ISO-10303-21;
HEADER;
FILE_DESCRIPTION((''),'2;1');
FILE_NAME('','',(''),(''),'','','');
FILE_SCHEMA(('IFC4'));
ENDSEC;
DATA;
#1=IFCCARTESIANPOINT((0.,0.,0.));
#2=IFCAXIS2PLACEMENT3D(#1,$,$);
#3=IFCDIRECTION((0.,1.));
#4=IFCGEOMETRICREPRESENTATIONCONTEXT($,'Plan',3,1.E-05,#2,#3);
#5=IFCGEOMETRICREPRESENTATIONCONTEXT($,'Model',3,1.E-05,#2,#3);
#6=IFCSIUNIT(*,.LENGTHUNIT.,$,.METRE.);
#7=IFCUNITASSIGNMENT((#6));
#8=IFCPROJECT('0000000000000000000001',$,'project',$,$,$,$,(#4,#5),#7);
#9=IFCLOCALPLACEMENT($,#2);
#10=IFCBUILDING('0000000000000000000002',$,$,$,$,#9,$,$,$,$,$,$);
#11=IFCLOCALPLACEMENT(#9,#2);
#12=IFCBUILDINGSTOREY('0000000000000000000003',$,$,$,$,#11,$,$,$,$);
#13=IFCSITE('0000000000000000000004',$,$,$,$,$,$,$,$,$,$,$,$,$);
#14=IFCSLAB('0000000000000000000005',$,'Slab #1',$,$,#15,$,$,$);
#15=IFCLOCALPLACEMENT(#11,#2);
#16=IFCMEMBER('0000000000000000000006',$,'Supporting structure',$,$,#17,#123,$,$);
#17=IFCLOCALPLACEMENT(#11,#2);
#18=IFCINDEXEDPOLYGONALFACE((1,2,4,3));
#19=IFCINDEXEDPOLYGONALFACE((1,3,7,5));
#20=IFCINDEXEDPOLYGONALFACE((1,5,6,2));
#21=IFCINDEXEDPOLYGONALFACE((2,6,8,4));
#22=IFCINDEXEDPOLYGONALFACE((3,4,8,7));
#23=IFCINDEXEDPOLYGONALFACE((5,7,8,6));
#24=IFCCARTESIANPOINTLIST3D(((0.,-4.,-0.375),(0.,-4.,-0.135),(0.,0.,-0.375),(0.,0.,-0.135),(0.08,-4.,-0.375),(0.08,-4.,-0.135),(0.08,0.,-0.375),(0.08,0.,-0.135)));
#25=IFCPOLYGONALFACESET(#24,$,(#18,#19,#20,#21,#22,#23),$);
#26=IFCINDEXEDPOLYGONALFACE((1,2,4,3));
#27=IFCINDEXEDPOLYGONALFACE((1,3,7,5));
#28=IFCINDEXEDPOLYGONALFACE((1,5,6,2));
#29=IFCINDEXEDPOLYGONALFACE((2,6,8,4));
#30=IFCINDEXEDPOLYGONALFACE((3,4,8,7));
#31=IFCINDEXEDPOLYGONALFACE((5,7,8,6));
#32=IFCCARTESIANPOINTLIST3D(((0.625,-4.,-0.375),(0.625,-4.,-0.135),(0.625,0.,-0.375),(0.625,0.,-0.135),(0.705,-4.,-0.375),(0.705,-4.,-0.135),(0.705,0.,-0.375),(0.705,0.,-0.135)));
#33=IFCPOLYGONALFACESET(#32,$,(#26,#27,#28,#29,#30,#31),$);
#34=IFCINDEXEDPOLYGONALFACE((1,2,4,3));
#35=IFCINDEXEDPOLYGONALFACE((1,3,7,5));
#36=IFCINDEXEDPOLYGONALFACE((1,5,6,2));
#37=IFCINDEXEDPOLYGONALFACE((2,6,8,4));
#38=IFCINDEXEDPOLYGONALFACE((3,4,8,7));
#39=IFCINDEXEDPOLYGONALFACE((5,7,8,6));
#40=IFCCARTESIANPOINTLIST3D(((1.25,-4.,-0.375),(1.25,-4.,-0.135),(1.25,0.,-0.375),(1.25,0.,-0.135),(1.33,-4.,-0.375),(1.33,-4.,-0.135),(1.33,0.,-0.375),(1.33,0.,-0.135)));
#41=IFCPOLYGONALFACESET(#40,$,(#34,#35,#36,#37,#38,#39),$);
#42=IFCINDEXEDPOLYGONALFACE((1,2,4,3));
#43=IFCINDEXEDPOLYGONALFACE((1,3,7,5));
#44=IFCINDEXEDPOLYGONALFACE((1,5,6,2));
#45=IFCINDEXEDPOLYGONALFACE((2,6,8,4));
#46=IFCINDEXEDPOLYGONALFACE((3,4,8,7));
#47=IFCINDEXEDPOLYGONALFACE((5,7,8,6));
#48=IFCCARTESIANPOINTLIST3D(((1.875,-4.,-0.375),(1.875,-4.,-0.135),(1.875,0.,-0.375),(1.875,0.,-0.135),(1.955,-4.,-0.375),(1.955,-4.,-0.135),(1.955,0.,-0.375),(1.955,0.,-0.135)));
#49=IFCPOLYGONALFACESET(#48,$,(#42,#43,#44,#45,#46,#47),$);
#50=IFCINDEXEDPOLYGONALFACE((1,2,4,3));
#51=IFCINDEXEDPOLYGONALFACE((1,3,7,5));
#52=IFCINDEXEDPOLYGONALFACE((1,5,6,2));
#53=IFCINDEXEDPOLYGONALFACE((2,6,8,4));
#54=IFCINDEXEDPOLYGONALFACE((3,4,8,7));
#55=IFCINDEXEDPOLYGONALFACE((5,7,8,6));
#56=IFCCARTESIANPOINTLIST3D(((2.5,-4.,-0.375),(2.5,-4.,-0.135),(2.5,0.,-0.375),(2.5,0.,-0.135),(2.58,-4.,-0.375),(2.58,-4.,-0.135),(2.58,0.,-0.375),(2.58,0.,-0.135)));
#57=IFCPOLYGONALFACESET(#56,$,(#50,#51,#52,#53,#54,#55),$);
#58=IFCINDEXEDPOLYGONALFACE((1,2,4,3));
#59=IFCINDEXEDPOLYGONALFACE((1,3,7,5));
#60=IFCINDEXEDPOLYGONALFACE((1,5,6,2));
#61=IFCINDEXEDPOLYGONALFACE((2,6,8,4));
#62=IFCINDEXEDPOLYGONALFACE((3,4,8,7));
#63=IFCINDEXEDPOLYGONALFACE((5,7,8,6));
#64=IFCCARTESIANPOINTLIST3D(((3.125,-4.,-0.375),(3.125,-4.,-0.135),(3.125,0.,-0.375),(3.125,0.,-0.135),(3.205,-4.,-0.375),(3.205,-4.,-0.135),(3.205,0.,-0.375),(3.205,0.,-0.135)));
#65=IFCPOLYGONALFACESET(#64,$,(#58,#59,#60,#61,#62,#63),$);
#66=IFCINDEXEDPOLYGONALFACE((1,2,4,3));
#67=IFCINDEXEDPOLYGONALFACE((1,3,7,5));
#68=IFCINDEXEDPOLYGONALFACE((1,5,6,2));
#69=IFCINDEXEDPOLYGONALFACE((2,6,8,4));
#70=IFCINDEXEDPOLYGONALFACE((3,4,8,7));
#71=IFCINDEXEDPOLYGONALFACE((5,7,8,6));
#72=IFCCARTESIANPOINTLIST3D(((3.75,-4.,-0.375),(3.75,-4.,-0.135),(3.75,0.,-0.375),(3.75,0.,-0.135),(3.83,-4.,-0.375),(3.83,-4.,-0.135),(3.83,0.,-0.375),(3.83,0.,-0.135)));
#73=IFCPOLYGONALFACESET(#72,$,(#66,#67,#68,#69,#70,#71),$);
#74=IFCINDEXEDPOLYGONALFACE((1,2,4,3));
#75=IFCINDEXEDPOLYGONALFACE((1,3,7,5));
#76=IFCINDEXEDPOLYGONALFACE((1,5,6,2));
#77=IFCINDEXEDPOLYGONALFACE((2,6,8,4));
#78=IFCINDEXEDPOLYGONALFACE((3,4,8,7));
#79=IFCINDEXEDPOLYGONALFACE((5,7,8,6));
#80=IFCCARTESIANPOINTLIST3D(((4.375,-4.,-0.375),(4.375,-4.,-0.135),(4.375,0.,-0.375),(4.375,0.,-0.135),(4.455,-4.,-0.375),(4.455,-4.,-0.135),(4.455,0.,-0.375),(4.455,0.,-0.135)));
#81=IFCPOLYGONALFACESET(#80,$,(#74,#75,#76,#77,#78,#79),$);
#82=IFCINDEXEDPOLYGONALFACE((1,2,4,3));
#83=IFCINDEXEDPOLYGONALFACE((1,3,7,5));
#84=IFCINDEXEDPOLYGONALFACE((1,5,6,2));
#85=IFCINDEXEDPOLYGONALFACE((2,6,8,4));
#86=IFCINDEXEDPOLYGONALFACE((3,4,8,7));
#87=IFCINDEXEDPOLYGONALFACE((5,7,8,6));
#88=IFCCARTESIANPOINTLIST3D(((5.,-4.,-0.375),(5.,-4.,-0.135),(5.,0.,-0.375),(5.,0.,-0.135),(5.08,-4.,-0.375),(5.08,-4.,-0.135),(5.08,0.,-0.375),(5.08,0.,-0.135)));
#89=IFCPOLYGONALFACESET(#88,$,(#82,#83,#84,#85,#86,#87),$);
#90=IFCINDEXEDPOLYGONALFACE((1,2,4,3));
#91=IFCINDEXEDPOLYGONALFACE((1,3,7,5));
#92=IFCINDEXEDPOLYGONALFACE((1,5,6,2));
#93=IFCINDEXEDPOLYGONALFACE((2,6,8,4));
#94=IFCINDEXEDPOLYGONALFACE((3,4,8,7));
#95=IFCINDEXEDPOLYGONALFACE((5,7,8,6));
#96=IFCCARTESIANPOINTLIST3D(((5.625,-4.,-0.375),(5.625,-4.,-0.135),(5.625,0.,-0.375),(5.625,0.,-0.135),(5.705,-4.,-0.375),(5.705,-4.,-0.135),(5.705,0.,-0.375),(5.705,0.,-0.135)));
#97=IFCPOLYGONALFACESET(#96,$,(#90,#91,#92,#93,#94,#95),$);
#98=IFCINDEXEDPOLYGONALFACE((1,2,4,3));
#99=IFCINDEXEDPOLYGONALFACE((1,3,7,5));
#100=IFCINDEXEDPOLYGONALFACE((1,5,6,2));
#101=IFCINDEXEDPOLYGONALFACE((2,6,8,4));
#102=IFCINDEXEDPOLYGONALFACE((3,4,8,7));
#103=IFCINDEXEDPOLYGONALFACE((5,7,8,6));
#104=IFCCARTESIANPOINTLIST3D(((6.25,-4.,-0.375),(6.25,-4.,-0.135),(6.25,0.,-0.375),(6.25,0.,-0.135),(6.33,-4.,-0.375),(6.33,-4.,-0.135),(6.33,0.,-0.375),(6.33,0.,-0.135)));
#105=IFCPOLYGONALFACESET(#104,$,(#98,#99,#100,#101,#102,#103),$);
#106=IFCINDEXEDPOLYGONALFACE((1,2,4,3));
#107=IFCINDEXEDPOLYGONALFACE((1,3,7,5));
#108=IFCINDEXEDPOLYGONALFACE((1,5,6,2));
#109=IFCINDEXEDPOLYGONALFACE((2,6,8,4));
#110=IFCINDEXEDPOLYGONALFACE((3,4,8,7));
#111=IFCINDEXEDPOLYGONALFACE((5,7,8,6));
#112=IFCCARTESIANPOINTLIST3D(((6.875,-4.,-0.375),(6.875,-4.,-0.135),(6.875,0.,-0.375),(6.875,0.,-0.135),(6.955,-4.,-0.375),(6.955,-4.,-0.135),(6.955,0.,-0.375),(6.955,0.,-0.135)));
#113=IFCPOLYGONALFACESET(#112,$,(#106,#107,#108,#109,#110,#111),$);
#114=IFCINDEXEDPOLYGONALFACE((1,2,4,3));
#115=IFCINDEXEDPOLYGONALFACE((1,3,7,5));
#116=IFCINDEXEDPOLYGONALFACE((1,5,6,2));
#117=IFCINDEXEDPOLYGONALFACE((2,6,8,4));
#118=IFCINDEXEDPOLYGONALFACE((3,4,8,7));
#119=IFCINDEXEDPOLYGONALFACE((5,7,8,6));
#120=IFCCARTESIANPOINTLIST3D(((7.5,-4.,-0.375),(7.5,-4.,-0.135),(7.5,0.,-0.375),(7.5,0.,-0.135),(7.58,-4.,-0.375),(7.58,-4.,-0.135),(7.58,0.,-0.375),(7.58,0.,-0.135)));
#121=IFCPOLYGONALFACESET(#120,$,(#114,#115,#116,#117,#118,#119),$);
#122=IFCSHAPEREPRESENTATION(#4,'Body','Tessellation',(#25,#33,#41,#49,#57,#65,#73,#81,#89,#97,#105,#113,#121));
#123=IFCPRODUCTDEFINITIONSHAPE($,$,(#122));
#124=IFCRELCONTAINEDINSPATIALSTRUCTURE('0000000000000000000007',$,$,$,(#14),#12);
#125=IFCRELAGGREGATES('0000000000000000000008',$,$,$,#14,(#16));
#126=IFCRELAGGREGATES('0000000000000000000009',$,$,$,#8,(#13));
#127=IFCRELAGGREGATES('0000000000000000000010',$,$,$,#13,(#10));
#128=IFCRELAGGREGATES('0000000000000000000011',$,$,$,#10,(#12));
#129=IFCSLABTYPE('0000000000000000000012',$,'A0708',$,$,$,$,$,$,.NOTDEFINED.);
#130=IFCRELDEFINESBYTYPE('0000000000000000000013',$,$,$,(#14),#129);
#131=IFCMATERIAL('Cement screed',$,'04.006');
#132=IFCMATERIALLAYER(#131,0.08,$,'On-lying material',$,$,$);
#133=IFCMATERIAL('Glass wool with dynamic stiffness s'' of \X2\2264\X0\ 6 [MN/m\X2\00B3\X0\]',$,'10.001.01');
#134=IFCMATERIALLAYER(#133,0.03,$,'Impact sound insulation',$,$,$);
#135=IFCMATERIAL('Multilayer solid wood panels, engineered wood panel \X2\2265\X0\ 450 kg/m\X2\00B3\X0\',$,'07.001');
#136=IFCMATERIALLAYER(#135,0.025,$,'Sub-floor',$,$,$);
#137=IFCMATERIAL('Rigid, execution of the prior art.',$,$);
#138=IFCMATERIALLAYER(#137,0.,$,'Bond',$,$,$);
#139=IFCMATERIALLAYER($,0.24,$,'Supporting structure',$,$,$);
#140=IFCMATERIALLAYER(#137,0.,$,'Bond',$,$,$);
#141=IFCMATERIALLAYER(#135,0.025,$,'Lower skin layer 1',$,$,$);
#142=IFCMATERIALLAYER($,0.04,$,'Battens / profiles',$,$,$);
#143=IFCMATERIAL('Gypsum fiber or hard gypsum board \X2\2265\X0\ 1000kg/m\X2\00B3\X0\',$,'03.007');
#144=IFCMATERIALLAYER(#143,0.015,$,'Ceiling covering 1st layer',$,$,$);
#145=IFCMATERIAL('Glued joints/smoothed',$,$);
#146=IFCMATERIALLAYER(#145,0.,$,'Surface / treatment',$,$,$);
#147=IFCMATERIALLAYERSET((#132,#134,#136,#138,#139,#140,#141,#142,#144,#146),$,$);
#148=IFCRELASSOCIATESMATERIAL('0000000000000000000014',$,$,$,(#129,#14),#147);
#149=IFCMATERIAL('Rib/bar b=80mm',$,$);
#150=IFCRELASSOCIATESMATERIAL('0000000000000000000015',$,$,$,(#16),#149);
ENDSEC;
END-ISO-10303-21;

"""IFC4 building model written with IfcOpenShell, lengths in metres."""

from ifc_helpers import new_model, si_unit, direction, frame, frame_2d, origin, place, context, project, spatial, rectangle, extrude, material, layer, layer_set, type_object, element, aggregate, save


model = new_model("IFC4")

# Units and contexts
plan_context = context("Plan", 3, precision=1e-05, world=origin(), true_north=direction((0.0, 1.0)))
model_context = context("Model", 3, precision=1e-05, world=origin(), true_north=direction((0.0, 1.0)))
ifc_project = project(units=[si_unit("LENGTHUNIT", "METRE")], contexts=[plan_context, model_context])

# Site, building, storey
site = spatial("IfcSite", under=ifc_project)
building_placement = place(None, origin())
building = spatial("IfcBuilding", under=site, at=building_placement)
storey_placement = place(building_placement, origin())
storey = spatial("IfcBuildingStorey", under=building, at=storey_placement)

# Slab, member
ifc_material_1 = material(Name="Cement screed", Category="04.006")
ifc_layer_1 = layer(ifc_material_1, 0.08, Name="On-lying material")
ifc_material_2 = material(Name="Glass wool with dynamic stiffness s' of ≤ 6 [MN/m³]", Category="10.001.01")
ifc_layer_2 = layer(ifc_material_2, 0.03, Name="Impact sound insulation")
ifc_material_3 = material(Name="Multilayer solid wood panels, engineered wood panel ≥ 450 kg/m³", Category="07.001")
ifc_layer_3 = layer(ifc_material_3, 0.025, Name="Sub-floor")
ifc_material_4 = material(Name="Rigid, execution of the prior art.")
ifc_layer_4 = layer(ifc_material_4, 0.0, Name="Bond")
ifc_layer_5 = layer(None, 0.24, Name="Supporting structure")
ifc_layer_6 = layer(ifc_material_4, 0.0, Name="Bond")
ifc_layer_7 = layer(ifc_material_3, 0.025, Name="Lower skin layer 1")
ifc_layer_8 = layer(None, 0.04, Name="Battens / profiles")
ifc_material_5 = material(Name="Gypsum fiber or hard gypsum board ≥ 1000kg/m³", Category="03.007")
ifc_layer_9 = layer(ifc_material_5, 0.015, Name="Ceiling covering 1st layer")
ifc_material_6 = material(Name="Glued joints/smoothed")
ifc_layer_10 = layer(ifc_material_6, 0.0, Name="Surface / treatment")
ifc_layer_set = layer_set([ifc_layer_1, ifc_layer_2, ifc_layer_3, ifc_layer_4, ifc_layer_5, ifc_layer_6, ifc_layer_7, ifc_layer_8, ifc_layer_9, ifc_layer_10])
slab_type = type_object("IfcSlabType", Name="A0708", PredefinedType="NOTDEFINED", material=ifc_layer_set)
slab_placement = place(None, frame((0.0, 0.0, 0.0), z_axis=(0.0, 0.0, -1.0), x_axis=(1.0, 0.0, 0.0)))
slab = element("IfcSlab", 1, at=slab_placement, inside=storey, type_object=slab_type, material=ifc_layer_set, Name="Slab #1")
ifc_material_7 = material(Name="Rib/bar b=80mm")
member_1_placement = place(slab_placement, origin())
member_1 = element("IfcMember", 2, at=member_1_placement, material=ifc_material_7, Name="Supporting structure", context=plan_context, shape_type="SweptSolid", body=[
    extrude(rectangle(XDim=0.08, YDim=0.24, at=frame_2d((0.04, 0.12), x_axis=(1.0, 0.0))), frame((0.0, 4.0, 0.135), z_axis=(0.0, -1.0, 0.0), x_axis=(1.0, 0.0, 0.0)), (0.0, 0.0, 1.0), 4.0),
    extrude(rectangle(XDim=0.08, YDim=0.24, at=frame_2d((0.04, 0.12), x_axis=(1.0, 0.0))), frame((0.625, 4.0, 0.135), z_axis=(0.0, -1.0, 0.0), x_axis=(1.0, 0.0, 0.0)), (0.0, 0.0, 1.0), 4.0),
    extrude(rectangle(XDim=0.08, YDim=0.24, at=frame_2d((0.04, 0.12), x_axis=(1.0, 0.0))), frame((1.25, 4.0, 0.135), z_axis=(0.0, -1.0, 0.0), x_axis=(1.0, 0.0, 0.0)), (0.0, 0.0, 1.0), 4.0),
    extrude(rectangle(XDim=0.08, YDim=0.24, at=frame_2d((0.04, 0.12), x_axis=(1.0, 0.0))), frame((1.875, 4.0, 0.135), z_axis=(0.0, -1.0, 0.0), x_axis=(1.0, 0.0, 0.0)), (0.0, 0.0, 1.0), 4.0),
    extrude(rectangle(XDim=0.08, YDim=0.24, at=frame_2d((0.04, 0.12), x_axis=(1.0, 0.0))), frame((2.5, 4.0, 0.135), z_axis=(0.0, -1.0, 0.0), x_axis=(1.0, 0.0, 0.0)), (0.0, 0.0, 1.0), 4.0),
    extrude(rectangle(XDim=0.08, YDim=0.24, at=frame_2d((0.04, 0.12), x_axis=(1.0, 0.0))), frame((3.125, 4.0, 0.135), z_axis=(0.0, -1.0, 0.0), x_axis=(1.0, 0.0, 0.0)), (0.0, 0.0, 1.0), 4.0),
    extrude(rectangle(XDim=0.08, YDim=0.24, at=frame_2d((0.04, 0.12), x_axis=(1.0, 0.0))), frame((3.75, 4.0, 0.135), z_axis=(0.0, -1.0, 0.0), x_axis=(1.0, 0.0, 0.0)), (0.0, 0.0, 1.0), 4.0),
    extrude(rectangle(XDim=0.08, YDim=0.24, at=frame_2d((0.04, 0.12), x_axis=(1.0, 0.0))), frame((4.375, 4.0, 0.135), z_axis=(0.0, -1.0, 0.0), x_axis=(1.0, 0.0, 0.0)), (0.0, 0.0, 1.0), 4.0),
    extrude(rectangle(XDim=0.08, YDim=0.24, at=frame_2d((0.04, 0.12), x_axis=(1.0, 0.0))), frame((5.0, 4.0, 0.135), z_axis=(0.0, -1.0, 0.0), x_axis=(1.0, 0.0, 0.0)), (0.0, 0.0, 1.0), 4.0),
    extrude(rectangle(XDim=0.08, YDim=0.24, at=frame_2d((0.04, 0.12), x_axis=(1.0, 0.0))), frame((5.625, 4.0, 0.135), z_axis=(0.0, -1.0, 0.0), x_axis=(1.0, 0.0, 0.0)), (0.0, 0.0, 1.0), 4.0),
    extrude(rectangle(XDim=0.08, YDim=0.24, at=frame_2d((0.04, 0.12), x_axis=(1.0, 0.0))), frame((6.25, 4.0, 0.135), z_axis=(0.0, -1.0, 0.0), x_axis=(1.0, 0.0, 0.0)), (0.0, 0.0, 1.0), 4.0),
    extrude(rectangle(XDim=0.08, YDim=0.24, at=frame_2d((0.04, 0.12), x_axis=(1.0, 0.0))), frame((6.875, 4.0, 0.135), z_axis=(0.0, -1.0, 0.0), x_axis=(1.0, 0.0, 0.0)), (0.0, 0.0, 1.0), 4.0),
    extrude(rectangle(XDim=0.08, YDim=0.24, at=frame_2d((0.04, 0.12), x_axis=(1.0, 0.0))), frame((7.5, 4.0, 0.135), z_axis=(0.0, -1.0, 0.0), x_axis=(1.0, 0.0, 0.0)), (0.0, 0.0, 1.0), 4.0),
])
aggregate(slab, [member_1])

save(model, "model.ifc")
